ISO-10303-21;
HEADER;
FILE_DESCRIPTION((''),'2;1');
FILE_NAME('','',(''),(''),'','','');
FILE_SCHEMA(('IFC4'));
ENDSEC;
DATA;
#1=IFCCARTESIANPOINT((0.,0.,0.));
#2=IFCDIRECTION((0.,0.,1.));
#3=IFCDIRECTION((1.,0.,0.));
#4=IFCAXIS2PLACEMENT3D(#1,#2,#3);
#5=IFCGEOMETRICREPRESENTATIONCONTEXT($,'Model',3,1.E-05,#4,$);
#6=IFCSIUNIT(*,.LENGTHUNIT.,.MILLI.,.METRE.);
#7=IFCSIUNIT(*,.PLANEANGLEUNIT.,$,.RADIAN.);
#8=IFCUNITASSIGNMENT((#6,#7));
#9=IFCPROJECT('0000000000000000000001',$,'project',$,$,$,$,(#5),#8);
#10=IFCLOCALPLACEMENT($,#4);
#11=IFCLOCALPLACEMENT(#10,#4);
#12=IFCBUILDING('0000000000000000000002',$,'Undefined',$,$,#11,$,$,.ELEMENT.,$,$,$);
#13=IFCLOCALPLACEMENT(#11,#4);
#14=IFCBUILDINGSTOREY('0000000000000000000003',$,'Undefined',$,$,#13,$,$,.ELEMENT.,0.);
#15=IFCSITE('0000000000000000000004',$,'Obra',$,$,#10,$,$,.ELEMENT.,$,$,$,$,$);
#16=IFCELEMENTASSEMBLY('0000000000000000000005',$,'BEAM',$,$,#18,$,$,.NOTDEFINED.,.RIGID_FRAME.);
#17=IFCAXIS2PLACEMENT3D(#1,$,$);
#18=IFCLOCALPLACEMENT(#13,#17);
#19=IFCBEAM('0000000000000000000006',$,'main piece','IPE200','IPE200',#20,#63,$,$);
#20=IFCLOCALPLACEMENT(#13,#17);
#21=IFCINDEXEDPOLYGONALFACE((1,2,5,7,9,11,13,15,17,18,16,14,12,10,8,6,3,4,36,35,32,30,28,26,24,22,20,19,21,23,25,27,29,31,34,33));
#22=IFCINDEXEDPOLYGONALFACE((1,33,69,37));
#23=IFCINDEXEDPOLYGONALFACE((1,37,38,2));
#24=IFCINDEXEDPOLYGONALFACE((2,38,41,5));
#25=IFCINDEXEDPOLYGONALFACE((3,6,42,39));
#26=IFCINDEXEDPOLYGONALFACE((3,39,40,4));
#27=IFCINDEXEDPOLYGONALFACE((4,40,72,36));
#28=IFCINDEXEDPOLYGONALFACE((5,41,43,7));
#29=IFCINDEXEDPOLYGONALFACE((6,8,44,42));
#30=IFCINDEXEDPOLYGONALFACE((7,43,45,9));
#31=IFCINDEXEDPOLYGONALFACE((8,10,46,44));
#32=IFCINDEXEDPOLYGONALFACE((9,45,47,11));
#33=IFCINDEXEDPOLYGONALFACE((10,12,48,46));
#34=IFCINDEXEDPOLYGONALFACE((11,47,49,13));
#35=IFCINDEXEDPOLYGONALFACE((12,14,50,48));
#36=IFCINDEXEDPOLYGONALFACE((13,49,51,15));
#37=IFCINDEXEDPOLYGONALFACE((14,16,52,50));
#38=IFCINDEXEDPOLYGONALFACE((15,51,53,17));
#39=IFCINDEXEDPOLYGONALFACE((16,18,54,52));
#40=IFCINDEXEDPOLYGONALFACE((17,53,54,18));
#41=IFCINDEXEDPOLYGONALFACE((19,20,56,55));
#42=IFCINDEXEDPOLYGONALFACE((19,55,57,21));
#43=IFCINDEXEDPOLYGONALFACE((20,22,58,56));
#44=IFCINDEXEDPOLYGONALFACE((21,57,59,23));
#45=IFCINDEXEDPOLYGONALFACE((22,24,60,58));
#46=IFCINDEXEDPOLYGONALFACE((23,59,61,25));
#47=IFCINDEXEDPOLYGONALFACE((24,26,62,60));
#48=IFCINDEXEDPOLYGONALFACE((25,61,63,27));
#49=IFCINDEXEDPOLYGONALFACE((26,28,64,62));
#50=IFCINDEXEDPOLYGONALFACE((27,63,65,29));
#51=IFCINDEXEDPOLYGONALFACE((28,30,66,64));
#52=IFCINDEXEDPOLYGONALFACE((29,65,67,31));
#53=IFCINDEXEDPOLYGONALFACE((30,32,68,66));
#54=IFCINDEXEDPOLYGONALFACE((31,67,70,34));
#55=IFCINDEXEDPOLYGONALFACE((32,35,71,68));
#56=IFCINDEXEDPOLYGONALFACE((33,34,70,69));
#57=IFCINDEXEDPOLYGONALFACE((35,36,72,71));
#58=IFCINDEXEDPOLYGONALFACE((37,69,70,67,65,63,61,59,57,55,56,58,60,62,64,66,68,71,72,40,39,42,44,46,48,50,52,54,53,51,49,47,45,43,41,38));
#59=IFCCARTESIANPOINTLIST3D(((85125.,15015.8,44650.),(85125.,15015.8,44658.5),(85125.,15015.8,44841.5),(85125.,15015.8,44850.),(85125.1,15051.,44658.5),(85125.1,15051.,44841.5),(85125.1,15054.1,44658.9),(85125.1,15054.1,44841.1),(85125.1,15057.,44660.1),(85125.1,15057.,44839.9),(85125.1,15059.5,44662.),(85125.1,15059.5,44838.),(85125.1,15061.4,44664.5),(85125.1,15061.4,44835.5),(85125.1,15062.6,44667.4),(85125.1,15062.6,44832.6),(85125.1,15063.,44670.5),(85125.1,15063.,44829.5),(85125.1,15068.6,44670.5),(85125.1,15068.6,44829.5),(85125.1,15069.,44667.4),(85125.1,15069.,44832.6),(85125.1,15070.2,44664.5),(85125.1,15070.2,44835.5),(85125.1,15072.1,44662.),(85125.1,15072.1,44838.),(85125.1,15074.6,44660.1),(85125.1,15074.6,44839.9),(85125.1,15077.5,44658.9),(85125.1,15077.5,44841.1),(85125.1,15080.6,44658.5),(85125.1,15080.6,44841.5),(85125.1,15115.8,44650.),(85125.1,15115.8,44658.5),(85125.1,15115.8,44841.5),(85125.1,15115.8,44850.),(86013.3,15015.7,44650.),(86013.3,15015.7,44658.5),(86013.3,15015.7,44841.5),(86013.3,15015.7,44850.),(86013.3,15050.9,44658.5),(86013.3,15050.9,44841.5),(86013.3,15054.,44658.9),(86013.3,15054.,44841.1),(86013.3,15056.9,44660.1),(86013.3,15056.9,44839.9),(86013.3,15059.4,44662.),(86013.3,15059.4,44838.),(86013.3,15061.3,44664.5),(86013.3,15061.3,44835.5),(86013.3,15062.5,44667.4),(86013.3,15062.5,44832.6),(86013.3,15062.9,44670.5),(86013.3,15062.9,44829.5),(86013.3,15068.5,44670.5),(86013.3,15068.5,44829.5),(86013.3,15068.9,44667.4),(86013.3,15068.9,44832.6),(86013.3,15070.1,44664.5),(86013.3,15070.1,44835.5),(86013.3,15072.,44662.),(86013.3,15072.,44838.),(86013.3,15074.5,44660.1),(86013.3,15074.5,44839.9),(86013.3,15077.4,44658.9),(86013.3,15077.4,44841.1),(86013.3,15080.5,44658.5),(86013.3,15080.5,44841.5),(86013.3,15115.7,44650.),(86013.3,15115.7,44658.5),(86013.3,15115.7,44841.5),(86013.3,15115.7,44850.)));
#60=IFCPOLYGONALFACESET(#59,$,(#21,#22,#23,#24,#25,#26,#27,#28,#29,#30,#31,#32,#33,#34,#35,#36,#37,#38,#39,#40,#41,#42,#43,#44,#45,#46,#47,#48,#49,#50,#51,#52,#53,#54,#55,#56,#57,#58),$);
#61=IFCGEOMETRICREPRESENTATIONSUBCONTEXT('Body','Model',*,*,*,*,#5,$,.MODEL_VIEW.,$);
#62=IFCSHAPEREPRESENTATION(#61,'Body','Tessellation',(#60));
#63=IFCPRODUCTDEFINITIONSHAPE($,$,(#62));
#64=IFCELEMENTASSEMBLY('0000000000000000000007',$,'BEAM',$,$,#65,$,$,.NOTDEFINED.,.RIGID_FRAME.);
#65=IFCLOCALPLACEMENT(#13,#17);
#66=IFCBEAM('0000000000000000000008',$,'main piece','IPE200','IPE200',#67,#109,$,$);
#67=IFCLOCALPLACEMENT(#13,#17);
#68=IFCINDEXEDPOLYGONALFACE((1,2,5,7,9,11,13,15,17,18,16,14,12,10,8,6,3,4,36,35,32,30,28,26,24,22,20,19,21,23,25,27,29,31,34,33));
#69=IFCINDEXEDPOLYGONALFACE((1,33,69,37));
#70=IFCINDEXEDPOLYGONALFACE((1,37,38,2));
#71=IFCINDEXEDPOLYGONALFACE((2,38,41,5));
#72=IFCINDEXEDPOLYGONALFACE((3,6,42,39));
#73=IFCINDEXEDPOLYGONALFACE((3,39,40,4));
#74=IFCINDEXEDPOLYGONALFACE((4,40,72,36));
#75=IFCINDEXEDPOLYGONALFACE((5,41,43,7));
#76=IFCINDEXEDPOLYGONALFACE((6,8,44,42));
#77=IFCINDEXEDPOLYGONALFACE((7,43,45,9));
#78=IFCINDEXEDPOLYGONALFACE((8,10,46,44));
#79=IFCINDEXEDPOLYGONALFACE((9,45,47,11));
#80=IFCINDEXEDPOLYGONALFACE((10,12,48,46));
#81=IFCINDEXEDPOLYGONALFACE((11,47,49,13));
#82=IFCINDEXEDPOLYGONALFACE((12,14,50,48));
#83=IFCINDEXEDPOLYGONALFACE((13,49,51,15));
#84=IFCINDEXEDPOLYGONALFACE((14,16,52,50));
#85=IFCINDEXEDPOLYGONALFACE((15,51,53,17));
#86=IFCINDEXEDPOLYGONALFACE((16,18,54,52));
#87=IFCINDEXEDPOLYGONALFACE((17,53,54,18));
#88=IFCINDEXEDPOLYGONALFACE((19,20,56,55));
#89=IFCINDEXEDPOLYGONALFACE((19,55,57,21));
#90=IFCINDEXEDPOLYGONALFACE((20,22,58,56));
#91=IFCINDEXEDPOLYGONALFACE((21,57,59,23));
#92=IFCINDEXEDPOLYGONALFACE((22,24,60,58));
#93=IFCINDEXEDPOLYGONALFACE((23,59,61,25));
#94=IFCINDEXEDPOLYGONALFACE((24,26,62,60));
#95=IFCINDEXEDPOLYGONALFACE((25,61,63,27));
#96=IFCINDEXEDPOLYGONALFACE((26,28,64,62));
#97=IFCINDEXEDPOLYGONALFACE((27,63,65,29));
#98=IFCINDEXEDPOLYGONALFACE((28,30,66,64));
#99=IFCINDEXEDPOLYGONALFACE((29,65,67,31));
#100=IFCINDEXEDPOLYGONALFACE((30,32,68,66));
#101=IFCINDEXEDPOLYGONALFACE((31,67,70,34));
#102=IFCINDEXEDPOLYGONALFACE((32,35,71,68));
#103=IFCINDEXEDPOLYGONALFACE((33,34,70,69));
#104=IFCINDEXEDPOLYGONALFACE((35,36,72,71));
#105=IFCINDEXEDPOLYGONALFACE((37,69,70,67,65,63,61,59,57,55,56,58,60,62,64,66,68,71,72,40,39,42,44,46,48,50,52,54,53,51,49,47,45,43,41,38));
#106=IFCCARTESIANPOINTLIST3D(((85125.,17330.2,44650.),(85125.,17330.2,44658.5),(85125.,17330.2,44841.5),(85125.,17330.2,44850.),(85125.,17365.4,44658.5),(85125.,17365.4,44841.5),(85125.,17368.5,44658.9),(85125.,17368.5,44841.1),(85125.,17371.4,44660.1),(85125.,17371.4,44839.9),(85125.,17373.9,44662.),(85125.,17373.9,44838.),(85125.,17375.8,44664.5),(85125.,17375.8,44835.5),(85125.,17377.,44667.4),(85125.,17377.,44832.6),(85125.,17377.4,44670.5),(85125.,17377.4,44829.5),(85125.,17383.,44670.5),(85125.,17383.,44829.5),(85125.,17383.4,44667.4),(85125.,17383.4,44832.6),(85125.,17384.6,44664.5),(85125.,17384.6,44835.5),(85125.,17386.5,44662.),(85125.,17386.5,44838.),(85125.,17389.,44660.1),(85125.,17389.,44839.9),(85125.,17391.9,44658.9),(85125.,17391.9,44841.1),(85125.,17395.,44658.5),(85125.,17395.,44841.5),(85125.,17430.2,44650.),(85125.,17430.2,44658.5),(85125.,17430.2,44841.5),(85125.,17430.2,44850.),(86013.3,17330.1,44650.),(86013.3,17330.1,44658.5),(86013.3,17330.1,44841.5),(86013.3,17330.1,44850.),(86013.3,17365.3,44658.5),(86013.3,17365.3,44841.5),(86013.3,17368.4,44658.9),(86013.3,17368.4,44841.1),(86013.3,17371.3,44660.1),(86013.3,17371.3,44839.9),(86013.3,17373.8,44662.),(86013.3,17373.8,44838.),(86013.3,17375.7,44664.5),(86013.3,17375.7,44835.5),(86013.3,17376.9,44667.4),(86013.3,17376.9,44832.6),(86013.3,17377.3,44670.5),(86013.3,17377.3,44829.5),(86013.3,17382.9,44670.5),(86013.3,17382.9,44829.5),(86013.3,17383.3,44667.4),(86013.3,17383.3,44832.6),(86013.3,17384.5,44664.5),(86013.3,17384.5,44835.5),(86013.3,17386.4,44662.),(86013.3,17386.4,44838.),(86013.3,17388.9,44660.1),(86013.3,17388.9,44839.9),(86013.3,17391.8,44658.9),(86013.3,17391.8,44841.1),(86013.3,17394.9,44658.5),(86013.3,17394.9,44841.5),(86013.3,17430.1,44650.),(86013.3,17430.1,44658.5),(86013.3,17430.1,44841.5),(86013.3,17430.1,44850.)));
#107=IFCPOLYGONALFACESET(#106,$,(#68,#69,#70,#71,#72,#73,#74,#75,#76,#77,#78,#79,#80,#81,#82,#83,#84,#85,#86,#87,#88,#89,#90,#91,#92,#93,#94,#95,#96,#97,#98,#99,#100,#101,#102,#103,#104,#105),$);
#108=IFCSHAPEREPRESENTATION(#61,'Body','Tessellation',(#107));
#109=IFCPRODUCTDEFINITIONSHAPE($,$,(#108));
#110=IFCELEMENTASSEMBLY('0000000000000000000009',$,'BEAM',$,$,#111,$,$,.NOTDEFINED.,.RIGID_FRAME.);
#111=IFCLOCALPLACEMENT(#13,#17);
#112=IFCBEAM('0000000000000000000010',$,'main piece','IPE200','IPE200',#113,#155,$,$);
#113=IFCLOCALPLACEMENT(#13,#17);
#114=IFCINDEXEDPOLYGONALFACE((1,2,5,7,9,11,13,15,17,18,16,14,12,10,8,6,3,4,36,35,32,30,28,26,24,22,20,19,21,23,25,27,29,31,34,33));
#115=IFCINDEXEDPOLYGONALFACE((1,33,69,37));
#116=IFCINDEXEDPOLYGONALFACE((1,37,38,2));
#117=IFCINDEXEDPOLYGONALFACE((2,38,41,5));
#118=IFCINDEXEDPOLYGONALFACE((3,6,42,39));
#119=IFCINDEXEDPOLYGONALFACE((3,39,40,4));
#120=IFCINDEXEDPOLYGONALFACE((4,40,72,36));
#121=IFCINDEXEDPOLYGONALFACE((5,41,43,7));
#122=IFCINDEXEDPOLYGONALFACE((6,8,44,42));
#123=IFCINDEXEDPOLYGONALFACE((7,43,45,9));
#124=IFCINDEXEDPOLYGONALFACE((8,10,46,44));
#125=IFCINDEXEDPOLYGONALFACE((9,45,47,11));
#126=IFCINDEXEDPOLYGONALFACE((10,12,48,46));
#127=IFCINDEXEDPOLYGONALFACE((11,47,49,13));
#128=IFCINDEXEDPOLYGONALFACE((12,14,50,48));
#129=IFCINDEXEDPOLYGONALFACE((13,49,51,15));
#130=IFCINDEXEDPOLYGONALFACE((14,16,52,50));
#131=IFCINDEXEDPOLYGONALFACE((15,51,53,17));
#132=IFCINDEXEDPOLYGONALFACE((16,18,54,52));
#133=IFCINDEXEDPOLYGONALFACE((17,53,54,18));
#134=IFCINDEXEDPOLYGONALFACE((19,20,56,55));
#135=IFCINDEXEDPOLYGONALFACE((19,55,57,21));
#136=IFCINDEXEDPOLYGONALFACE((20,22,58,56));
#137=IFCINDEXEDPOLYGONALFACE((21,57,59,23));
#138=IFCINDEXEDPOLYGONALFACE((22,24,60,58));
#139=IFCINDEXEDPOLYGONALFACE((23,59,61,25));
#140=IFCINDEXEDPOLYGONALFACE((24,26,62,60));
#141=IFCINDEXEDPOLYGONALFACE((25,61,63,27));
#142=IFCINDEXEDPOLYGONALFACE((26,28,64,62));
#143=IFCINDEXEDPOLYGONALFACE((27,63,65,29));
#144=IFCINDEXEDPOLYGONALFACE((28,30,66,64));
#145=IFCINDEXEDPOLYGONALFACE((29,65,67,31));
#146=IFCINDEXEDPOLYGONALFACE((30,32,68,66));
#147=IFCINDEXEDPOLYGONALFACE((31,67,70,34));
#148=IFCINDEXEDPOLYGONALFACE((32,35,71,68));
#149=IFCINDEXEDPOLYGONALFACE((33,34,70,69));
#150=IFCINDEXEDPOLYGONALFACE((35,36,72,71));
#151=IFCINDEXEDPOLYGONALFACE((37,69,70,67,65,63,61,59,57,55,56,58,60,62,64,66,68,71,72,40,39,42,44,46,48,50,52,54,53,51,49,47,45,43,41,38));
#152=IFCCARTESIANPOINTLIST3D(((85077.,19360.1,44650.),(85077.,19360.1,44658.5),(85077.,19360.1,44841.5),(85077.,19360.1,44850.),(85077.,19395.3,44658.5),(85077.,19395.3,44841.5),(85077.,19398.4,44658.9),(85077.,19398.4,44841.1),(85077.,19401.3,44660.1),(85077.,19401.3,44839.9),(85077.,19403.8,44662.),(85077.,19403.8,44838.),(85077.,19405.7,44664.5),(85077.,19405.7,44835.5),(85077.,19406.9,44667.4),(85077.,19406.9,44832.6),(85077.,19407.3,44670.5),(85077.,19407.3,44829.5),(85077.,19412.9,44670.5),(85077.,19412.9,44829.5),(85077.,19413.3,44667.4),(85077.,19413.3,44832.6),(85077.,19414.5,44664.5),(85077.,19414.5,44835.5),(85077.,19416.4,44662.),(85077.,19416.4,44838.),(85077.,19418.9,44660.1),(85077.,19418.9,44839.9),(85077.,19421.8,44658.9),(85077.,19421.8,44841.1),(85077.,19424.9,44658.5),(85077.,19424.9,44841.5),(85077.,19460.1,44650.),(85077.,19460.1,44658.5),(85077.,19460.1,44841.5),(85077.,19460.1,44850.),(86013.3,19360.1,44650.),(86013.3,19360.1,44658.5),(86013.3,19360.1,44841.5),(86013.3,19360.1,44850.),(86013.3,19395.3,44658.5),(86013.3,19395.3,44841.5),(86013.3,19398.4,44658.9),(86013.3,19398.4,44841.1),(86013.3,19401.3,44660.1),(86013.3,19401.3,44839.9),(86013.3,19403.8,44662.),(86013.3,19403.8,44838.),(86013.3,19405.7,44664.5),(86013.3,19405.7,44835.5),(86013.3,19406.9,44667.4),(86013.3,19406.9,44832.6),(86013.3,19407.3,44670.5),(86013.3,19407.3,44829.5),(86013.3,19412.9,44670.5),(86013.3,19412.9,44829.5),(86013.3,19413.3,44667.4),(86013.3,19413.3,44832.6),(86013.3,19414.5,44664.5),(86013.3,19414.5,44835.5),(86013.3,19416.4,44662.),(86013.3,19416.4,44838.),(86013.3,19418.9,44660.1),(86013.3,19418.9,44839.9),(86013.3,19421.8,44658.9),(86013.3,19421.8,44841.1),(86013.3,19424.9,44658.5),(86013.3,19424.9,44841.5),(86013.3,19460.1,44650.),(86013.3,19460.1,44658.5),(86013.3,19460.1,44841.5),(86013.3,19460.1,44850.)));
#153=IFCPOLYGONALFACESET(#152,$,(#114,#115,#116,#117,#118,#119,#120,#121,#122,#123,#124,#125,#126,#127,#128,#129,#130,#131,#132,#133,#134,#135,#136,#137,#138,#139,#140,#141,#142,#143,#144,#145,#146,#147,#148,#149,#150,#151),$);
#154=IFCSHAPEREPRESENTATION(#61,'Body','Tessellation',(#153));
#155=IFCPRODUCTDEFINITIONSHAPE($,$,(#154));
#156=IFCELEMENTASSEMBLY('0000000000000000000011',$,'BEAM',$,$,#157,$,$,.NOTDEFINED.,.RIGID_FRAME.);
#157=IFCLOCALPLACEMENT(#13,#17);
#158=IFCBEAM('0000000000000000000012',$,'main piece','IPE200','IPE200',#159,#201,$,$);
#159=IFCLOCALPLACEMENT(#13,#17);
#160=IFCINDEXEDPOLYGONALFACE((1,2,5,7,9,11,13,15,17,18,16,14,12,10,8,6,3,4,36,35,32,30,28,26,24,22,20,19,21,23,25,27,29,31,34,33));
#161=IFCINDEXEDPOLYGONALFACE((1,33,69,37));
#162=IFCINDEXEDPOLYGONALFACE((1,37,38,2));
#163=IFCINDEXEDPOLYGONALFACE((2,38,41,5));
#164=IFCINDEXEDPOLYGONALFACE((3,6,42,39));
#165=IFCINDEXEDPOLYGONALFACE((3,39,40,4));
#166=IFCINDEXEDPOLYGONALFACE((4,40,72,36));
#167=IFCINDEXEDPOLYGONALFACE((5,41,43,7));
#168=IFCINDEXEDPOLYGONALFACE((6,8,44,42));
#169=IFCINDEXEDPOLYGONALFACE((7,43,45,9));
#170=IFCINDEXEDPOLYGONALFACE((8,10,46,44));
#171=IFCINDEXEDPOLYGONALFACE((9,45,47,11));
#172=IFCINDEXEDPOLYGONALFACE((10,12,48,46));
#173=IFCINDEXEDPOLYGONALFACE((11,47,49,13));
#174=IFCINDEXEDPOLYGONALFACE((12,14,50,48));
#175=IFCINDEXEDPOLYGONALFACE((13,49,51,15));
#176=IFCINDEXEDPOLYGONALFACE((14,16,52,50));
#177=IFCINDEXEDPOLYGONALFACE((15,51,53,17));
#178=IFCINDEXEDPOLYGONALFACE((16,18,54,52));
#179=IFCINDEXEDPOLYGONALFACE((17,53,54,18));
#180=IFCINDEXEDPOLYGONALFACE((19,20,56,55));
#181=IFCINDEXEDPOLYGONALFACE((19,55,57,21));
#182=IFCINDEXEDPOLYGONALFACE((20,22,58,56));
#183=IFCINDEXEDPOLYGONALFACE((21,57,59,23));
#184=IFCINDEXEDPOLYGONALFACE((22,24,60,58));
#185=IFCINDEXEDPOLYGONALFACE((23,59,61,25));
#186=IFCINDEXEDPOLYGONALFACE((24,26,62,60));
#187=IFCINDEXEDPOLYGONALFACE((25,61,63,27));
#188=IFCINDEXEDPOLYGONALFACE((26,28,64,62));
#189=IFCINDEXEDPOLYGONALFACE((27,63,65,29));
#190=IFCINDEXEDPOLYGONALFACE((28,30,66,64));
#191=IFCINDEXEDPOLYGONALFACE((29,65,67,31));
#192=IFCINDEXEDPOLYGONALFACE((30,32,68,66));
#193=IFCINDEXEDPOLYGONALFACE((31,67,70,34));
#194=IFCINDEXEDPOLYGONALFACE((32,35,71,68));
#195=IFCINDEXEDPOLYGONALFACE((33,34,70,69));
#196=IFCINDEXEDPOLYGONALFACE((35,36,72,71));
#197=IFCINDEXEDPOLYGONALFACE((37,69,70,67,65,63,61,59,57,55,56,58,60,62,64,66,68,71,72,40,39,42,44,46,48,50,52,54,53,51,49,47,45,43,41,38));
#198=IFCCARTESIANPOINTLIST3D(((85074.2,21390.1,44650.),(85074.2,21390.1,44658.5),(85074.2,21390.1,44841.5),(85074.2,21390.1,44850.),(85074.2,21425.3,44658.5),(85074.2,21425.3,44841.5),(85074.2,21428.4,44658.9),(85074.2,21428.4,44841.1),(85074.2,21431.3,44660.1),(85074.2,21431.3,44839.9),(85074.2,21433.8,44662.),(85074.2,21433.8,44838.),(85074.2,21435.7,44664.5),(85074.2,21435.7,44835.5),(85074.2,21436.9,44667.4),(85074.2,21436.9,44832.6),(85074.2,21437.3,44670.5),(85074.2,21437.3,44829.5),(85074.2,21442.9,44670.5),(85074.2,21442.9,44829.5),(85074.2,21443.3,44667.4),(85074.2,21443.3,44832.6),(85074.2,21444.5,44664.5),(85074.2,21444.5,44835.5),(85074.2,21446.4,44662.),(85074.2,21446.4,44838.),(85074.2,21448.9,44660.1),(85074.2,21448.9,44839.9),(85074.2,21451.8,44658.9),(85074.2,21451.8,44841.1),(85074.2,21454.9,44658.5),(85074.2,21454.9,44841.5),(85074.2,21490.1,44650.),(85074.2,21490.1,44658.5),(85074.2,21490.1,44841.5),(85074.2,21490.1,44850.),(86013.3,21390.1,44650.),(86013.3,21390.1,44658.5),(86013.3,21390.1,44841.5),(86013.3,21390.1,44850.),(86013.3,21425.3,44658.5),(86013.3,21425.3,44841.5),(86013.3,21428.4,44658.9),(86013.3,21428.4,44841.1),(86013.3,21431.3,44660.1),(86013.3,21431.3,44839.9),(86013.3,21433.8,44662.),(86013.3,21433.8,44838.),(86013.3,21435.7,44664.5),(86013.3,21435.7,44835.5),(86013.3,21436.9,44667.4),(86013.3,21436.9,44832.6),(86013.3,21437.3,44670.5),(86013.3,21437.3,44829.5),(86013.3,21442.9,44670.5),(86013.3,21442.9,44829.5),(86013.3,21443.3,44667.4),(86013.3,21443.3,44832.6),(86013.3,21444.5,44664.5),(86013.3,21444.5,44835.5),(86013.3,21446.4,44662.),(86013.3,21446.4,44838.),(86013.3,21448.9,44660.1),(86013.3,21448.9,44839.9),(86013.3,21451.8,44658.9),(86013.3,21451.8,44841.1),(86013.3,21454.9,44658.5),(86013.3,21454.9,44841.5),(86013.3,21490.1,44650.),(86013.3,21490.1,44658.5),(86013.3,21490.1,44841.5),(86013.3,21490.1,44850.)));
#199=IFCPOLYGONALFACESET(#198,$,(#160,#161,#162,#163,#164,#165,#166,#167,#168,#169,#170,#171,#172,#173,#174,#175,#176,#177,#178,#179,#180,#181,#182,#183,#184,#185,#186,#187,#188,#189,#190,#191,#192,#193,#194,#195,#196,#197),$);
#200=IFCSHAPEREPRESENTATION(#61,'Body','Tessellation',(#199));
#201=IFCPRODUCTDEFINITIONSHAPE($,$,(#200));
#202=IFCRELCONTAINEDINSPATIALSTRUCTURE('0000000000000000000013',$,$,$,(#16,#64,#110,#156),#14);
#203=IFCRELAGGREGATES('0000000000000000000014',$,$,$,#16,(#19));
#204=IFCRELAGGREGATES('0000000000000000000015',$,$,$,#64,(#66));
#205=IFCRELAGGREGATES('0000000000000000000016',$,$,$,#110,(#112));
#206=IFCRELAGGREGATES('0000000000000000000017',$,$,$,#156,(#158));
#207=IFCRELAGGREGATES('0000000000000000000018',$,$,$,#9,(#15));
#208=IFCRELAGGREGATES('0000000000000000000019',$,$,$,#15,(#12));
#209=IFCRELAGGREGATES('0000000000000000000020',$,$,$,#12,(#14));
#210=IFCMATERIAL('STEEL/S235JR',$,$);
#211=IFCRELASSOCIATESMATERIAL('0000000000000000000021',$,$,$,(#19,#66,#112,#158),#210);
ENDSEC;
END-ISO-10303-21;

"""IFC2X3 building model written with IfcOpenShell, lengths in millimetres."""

from ifc_helpers import new_model, si_unit, frame, origin_with_axes, origin_2d_with_axis, place, context, subcontext, project, spatial, i_section, extrude, material, element, aggregate, save


model = new_model("IFC2X3")

# Units and contexts
model_context = context("Model", 3, precision=1e-05, world=origin_with_axes())
body_context = subcontext(model_context, "Body", "Model", "MODEL_VIEW")
ifc_project = project(units=[si_unit("LENGTHUNIT", "METRE", prefix="MILLI"), si_unit("PLANEANGLEUNIT", "RADIAN")], contexts=[model_context])

# Site, building, storey
site_placement = place(None, origin_with_axes())
site = spatial("IfcSite", under=ifc_project, at=site_placement, Name="Obra", CompositionType="ELEMENT")
building_placement = place(site_placement, origin_with_axes())
building = spatial("IfcBuilding", under=site, at=building_placement, Name="Undefined", CompositionType="ELEMENT")
storey_placement = place(building_placement, origin_with_axes())
storey = spatial("IfcBuildingStorey", under=building, at=storey_placement, Name="Undefined", CompositionType="ELEMENT", Elevation=0.0)

# Shared definitions
ifc_material = material(Name="STEEL/S235JR")

# Element assemblies, beams
assembly_1_placement = place(storey_placement, origin_with_axes())
assembly_1 = element("IfcElementAssembly", 1, at=assembly_1_placement, inside=storey, Name="BEAM", AssemblyPlace="NOTDEFINED", PredefinedType="RIGID_FRAME")
beam_1_placement = place(assembly_1_placement, frame((85125.0, 15065.8, 44750.0), z_axis=(0.0, 0.0, 1.0), x_axis=(1.0, -0.000043, 0.0)))
beam_1 = element("IfcBeam", 2, at=beam_1_placement, material=ifc_material, Name="main piece", Description="IPE200", ObjectType="IPE200", context=body_context, shape_type="SweptSolid", body=[
    extrude(i_section(OverallWidth=100.0, OverallDepth=200.0, WebThickness=5.6, FlangeThickness=8.5, FilletRadius=12.0, at=origin_2d_with_axis()), frame((888.3, 0.0, 0.0), z_axis=(-1.0, 0.0, 0.0), x_axis=(0.0, -1.0, 0.0)), (0.0, 0.0, 1.0), 888.2),
])
aggregate(assembly_1, [beam_1])
assembly_2_placement = place(storey_placement, origin_with_axes())
assembly_2 = element("IfcElementAssembly", 3, at=assembly_2_placement, inside=storey, Name="BEAM", AssemblyPlace="NOTDEFINED", PredefinedType="RIGID_FRAME")
beam_2_placement = place(assembly_2_placement, frame((85125.0, 17380.2, 44750.0), z_axis=(0.0, 0.0, 1.0), x_axis=(1.0, -0.000084, 0.0)))
beam_2 = element("IfcBeam", 4, at=beam_2_placement, material=ifc_material, Name="main piece", Description="IPE200", ObjectType="IPE200", context=body_context, shape_type="SweptSolid", body=[
    extrude(i_section(OverallWidth=100.0, OverallDepth=200.0, WebThickness=5.6, FlangeThickness=8.5, FilletRadius=12.0, at=origin_2d_with_axis()), frame((888.3, 0.0, 0.0), z_axis=(-1.0, 0.0, 0.0), x_axis=(0.0, -1.0, 0.0)), (0.0, 0.0, 1.0), 888.3),
])
aggregate(assembly_2, [beam_2])
assembly_3_placement = place(storey_placement, origin_with_axes())
assembly_3 = element("IfcElementAssembly", 5, at=assembly_3_placement, inside=storey, Name="BEAM", AssemblyPlace="NOTDEFINED", PredefinedType="RIGID_FRAME")
beam_3_placement = place(assembly_3_placement, frame((85077.0, 19410.1, 44750.0), z_axis=(0.0, 0.0, 1.0), x_axis=(1.0, 0.0, 0.0)))
beam_3 = element("IfcBeam", 6, at=beam_3_placement, material=ifc_material, Name="main piece", Description="IPE200", ObjectType="IPE200", context=body_context, shape_type="SweptSolid", body=[
    extrude(i_section(OverallWidth=100.0, OverallDepth=200.0, WebThickness=5.6, FlangeThickness=8.5, FilletRadius=12.0, at=origin_2d_with_axis()), frame((936.3, 0.0, 0.0), z_axis=(-1.0, 0.0, 0.0), x_axis=(0.0, -1.0, 0.0)), (0.0, 0.0, 1.0), 936.3),
])
aggregate(assembly_3, [beam_3])
assembly_4_placement = place(storey_placement, origin_with_axes())
assembly_4 = element("IfcElementAssembly", 7, at=assembly_4_placement, inside=storey, Name="BEAM", AssemblyPlace="NOTDEFINED", PredefinedType="RIGID_FRAME")
beam_4_placement = place(assembly_4_placement, frame((85074.2, 21440.1, 44750.0), z_axis=(0.0, 0.0, 1.0), x_axis=(1.0, 0.0, 0.0)))
beam_4 = element("IfcBeam", 8, at=beam_4_placement, material=ifc_material, Name="main piece", Description="IPE200", ObjectType="IPE200", context=body_context, shape_type="SweptSolid", body=[
    extrude(i_section(OverallWidth=100.0, OverallDepth=200.0, WebThickness=5.6, FlangeThickness=8.5, FilletRadius=12.0, at=origin_2d_with_axis()), frame((939.1, 0.0, 0.0), z_axis=(-1.0, 0.0, 0.0), x_axis=(0.0, -1.0, 0.0)), (0.0, 0.0, 1.0), 939.1),
])
aggregate(assembly_4, [beam_4])

save(model, "model.ifc")
